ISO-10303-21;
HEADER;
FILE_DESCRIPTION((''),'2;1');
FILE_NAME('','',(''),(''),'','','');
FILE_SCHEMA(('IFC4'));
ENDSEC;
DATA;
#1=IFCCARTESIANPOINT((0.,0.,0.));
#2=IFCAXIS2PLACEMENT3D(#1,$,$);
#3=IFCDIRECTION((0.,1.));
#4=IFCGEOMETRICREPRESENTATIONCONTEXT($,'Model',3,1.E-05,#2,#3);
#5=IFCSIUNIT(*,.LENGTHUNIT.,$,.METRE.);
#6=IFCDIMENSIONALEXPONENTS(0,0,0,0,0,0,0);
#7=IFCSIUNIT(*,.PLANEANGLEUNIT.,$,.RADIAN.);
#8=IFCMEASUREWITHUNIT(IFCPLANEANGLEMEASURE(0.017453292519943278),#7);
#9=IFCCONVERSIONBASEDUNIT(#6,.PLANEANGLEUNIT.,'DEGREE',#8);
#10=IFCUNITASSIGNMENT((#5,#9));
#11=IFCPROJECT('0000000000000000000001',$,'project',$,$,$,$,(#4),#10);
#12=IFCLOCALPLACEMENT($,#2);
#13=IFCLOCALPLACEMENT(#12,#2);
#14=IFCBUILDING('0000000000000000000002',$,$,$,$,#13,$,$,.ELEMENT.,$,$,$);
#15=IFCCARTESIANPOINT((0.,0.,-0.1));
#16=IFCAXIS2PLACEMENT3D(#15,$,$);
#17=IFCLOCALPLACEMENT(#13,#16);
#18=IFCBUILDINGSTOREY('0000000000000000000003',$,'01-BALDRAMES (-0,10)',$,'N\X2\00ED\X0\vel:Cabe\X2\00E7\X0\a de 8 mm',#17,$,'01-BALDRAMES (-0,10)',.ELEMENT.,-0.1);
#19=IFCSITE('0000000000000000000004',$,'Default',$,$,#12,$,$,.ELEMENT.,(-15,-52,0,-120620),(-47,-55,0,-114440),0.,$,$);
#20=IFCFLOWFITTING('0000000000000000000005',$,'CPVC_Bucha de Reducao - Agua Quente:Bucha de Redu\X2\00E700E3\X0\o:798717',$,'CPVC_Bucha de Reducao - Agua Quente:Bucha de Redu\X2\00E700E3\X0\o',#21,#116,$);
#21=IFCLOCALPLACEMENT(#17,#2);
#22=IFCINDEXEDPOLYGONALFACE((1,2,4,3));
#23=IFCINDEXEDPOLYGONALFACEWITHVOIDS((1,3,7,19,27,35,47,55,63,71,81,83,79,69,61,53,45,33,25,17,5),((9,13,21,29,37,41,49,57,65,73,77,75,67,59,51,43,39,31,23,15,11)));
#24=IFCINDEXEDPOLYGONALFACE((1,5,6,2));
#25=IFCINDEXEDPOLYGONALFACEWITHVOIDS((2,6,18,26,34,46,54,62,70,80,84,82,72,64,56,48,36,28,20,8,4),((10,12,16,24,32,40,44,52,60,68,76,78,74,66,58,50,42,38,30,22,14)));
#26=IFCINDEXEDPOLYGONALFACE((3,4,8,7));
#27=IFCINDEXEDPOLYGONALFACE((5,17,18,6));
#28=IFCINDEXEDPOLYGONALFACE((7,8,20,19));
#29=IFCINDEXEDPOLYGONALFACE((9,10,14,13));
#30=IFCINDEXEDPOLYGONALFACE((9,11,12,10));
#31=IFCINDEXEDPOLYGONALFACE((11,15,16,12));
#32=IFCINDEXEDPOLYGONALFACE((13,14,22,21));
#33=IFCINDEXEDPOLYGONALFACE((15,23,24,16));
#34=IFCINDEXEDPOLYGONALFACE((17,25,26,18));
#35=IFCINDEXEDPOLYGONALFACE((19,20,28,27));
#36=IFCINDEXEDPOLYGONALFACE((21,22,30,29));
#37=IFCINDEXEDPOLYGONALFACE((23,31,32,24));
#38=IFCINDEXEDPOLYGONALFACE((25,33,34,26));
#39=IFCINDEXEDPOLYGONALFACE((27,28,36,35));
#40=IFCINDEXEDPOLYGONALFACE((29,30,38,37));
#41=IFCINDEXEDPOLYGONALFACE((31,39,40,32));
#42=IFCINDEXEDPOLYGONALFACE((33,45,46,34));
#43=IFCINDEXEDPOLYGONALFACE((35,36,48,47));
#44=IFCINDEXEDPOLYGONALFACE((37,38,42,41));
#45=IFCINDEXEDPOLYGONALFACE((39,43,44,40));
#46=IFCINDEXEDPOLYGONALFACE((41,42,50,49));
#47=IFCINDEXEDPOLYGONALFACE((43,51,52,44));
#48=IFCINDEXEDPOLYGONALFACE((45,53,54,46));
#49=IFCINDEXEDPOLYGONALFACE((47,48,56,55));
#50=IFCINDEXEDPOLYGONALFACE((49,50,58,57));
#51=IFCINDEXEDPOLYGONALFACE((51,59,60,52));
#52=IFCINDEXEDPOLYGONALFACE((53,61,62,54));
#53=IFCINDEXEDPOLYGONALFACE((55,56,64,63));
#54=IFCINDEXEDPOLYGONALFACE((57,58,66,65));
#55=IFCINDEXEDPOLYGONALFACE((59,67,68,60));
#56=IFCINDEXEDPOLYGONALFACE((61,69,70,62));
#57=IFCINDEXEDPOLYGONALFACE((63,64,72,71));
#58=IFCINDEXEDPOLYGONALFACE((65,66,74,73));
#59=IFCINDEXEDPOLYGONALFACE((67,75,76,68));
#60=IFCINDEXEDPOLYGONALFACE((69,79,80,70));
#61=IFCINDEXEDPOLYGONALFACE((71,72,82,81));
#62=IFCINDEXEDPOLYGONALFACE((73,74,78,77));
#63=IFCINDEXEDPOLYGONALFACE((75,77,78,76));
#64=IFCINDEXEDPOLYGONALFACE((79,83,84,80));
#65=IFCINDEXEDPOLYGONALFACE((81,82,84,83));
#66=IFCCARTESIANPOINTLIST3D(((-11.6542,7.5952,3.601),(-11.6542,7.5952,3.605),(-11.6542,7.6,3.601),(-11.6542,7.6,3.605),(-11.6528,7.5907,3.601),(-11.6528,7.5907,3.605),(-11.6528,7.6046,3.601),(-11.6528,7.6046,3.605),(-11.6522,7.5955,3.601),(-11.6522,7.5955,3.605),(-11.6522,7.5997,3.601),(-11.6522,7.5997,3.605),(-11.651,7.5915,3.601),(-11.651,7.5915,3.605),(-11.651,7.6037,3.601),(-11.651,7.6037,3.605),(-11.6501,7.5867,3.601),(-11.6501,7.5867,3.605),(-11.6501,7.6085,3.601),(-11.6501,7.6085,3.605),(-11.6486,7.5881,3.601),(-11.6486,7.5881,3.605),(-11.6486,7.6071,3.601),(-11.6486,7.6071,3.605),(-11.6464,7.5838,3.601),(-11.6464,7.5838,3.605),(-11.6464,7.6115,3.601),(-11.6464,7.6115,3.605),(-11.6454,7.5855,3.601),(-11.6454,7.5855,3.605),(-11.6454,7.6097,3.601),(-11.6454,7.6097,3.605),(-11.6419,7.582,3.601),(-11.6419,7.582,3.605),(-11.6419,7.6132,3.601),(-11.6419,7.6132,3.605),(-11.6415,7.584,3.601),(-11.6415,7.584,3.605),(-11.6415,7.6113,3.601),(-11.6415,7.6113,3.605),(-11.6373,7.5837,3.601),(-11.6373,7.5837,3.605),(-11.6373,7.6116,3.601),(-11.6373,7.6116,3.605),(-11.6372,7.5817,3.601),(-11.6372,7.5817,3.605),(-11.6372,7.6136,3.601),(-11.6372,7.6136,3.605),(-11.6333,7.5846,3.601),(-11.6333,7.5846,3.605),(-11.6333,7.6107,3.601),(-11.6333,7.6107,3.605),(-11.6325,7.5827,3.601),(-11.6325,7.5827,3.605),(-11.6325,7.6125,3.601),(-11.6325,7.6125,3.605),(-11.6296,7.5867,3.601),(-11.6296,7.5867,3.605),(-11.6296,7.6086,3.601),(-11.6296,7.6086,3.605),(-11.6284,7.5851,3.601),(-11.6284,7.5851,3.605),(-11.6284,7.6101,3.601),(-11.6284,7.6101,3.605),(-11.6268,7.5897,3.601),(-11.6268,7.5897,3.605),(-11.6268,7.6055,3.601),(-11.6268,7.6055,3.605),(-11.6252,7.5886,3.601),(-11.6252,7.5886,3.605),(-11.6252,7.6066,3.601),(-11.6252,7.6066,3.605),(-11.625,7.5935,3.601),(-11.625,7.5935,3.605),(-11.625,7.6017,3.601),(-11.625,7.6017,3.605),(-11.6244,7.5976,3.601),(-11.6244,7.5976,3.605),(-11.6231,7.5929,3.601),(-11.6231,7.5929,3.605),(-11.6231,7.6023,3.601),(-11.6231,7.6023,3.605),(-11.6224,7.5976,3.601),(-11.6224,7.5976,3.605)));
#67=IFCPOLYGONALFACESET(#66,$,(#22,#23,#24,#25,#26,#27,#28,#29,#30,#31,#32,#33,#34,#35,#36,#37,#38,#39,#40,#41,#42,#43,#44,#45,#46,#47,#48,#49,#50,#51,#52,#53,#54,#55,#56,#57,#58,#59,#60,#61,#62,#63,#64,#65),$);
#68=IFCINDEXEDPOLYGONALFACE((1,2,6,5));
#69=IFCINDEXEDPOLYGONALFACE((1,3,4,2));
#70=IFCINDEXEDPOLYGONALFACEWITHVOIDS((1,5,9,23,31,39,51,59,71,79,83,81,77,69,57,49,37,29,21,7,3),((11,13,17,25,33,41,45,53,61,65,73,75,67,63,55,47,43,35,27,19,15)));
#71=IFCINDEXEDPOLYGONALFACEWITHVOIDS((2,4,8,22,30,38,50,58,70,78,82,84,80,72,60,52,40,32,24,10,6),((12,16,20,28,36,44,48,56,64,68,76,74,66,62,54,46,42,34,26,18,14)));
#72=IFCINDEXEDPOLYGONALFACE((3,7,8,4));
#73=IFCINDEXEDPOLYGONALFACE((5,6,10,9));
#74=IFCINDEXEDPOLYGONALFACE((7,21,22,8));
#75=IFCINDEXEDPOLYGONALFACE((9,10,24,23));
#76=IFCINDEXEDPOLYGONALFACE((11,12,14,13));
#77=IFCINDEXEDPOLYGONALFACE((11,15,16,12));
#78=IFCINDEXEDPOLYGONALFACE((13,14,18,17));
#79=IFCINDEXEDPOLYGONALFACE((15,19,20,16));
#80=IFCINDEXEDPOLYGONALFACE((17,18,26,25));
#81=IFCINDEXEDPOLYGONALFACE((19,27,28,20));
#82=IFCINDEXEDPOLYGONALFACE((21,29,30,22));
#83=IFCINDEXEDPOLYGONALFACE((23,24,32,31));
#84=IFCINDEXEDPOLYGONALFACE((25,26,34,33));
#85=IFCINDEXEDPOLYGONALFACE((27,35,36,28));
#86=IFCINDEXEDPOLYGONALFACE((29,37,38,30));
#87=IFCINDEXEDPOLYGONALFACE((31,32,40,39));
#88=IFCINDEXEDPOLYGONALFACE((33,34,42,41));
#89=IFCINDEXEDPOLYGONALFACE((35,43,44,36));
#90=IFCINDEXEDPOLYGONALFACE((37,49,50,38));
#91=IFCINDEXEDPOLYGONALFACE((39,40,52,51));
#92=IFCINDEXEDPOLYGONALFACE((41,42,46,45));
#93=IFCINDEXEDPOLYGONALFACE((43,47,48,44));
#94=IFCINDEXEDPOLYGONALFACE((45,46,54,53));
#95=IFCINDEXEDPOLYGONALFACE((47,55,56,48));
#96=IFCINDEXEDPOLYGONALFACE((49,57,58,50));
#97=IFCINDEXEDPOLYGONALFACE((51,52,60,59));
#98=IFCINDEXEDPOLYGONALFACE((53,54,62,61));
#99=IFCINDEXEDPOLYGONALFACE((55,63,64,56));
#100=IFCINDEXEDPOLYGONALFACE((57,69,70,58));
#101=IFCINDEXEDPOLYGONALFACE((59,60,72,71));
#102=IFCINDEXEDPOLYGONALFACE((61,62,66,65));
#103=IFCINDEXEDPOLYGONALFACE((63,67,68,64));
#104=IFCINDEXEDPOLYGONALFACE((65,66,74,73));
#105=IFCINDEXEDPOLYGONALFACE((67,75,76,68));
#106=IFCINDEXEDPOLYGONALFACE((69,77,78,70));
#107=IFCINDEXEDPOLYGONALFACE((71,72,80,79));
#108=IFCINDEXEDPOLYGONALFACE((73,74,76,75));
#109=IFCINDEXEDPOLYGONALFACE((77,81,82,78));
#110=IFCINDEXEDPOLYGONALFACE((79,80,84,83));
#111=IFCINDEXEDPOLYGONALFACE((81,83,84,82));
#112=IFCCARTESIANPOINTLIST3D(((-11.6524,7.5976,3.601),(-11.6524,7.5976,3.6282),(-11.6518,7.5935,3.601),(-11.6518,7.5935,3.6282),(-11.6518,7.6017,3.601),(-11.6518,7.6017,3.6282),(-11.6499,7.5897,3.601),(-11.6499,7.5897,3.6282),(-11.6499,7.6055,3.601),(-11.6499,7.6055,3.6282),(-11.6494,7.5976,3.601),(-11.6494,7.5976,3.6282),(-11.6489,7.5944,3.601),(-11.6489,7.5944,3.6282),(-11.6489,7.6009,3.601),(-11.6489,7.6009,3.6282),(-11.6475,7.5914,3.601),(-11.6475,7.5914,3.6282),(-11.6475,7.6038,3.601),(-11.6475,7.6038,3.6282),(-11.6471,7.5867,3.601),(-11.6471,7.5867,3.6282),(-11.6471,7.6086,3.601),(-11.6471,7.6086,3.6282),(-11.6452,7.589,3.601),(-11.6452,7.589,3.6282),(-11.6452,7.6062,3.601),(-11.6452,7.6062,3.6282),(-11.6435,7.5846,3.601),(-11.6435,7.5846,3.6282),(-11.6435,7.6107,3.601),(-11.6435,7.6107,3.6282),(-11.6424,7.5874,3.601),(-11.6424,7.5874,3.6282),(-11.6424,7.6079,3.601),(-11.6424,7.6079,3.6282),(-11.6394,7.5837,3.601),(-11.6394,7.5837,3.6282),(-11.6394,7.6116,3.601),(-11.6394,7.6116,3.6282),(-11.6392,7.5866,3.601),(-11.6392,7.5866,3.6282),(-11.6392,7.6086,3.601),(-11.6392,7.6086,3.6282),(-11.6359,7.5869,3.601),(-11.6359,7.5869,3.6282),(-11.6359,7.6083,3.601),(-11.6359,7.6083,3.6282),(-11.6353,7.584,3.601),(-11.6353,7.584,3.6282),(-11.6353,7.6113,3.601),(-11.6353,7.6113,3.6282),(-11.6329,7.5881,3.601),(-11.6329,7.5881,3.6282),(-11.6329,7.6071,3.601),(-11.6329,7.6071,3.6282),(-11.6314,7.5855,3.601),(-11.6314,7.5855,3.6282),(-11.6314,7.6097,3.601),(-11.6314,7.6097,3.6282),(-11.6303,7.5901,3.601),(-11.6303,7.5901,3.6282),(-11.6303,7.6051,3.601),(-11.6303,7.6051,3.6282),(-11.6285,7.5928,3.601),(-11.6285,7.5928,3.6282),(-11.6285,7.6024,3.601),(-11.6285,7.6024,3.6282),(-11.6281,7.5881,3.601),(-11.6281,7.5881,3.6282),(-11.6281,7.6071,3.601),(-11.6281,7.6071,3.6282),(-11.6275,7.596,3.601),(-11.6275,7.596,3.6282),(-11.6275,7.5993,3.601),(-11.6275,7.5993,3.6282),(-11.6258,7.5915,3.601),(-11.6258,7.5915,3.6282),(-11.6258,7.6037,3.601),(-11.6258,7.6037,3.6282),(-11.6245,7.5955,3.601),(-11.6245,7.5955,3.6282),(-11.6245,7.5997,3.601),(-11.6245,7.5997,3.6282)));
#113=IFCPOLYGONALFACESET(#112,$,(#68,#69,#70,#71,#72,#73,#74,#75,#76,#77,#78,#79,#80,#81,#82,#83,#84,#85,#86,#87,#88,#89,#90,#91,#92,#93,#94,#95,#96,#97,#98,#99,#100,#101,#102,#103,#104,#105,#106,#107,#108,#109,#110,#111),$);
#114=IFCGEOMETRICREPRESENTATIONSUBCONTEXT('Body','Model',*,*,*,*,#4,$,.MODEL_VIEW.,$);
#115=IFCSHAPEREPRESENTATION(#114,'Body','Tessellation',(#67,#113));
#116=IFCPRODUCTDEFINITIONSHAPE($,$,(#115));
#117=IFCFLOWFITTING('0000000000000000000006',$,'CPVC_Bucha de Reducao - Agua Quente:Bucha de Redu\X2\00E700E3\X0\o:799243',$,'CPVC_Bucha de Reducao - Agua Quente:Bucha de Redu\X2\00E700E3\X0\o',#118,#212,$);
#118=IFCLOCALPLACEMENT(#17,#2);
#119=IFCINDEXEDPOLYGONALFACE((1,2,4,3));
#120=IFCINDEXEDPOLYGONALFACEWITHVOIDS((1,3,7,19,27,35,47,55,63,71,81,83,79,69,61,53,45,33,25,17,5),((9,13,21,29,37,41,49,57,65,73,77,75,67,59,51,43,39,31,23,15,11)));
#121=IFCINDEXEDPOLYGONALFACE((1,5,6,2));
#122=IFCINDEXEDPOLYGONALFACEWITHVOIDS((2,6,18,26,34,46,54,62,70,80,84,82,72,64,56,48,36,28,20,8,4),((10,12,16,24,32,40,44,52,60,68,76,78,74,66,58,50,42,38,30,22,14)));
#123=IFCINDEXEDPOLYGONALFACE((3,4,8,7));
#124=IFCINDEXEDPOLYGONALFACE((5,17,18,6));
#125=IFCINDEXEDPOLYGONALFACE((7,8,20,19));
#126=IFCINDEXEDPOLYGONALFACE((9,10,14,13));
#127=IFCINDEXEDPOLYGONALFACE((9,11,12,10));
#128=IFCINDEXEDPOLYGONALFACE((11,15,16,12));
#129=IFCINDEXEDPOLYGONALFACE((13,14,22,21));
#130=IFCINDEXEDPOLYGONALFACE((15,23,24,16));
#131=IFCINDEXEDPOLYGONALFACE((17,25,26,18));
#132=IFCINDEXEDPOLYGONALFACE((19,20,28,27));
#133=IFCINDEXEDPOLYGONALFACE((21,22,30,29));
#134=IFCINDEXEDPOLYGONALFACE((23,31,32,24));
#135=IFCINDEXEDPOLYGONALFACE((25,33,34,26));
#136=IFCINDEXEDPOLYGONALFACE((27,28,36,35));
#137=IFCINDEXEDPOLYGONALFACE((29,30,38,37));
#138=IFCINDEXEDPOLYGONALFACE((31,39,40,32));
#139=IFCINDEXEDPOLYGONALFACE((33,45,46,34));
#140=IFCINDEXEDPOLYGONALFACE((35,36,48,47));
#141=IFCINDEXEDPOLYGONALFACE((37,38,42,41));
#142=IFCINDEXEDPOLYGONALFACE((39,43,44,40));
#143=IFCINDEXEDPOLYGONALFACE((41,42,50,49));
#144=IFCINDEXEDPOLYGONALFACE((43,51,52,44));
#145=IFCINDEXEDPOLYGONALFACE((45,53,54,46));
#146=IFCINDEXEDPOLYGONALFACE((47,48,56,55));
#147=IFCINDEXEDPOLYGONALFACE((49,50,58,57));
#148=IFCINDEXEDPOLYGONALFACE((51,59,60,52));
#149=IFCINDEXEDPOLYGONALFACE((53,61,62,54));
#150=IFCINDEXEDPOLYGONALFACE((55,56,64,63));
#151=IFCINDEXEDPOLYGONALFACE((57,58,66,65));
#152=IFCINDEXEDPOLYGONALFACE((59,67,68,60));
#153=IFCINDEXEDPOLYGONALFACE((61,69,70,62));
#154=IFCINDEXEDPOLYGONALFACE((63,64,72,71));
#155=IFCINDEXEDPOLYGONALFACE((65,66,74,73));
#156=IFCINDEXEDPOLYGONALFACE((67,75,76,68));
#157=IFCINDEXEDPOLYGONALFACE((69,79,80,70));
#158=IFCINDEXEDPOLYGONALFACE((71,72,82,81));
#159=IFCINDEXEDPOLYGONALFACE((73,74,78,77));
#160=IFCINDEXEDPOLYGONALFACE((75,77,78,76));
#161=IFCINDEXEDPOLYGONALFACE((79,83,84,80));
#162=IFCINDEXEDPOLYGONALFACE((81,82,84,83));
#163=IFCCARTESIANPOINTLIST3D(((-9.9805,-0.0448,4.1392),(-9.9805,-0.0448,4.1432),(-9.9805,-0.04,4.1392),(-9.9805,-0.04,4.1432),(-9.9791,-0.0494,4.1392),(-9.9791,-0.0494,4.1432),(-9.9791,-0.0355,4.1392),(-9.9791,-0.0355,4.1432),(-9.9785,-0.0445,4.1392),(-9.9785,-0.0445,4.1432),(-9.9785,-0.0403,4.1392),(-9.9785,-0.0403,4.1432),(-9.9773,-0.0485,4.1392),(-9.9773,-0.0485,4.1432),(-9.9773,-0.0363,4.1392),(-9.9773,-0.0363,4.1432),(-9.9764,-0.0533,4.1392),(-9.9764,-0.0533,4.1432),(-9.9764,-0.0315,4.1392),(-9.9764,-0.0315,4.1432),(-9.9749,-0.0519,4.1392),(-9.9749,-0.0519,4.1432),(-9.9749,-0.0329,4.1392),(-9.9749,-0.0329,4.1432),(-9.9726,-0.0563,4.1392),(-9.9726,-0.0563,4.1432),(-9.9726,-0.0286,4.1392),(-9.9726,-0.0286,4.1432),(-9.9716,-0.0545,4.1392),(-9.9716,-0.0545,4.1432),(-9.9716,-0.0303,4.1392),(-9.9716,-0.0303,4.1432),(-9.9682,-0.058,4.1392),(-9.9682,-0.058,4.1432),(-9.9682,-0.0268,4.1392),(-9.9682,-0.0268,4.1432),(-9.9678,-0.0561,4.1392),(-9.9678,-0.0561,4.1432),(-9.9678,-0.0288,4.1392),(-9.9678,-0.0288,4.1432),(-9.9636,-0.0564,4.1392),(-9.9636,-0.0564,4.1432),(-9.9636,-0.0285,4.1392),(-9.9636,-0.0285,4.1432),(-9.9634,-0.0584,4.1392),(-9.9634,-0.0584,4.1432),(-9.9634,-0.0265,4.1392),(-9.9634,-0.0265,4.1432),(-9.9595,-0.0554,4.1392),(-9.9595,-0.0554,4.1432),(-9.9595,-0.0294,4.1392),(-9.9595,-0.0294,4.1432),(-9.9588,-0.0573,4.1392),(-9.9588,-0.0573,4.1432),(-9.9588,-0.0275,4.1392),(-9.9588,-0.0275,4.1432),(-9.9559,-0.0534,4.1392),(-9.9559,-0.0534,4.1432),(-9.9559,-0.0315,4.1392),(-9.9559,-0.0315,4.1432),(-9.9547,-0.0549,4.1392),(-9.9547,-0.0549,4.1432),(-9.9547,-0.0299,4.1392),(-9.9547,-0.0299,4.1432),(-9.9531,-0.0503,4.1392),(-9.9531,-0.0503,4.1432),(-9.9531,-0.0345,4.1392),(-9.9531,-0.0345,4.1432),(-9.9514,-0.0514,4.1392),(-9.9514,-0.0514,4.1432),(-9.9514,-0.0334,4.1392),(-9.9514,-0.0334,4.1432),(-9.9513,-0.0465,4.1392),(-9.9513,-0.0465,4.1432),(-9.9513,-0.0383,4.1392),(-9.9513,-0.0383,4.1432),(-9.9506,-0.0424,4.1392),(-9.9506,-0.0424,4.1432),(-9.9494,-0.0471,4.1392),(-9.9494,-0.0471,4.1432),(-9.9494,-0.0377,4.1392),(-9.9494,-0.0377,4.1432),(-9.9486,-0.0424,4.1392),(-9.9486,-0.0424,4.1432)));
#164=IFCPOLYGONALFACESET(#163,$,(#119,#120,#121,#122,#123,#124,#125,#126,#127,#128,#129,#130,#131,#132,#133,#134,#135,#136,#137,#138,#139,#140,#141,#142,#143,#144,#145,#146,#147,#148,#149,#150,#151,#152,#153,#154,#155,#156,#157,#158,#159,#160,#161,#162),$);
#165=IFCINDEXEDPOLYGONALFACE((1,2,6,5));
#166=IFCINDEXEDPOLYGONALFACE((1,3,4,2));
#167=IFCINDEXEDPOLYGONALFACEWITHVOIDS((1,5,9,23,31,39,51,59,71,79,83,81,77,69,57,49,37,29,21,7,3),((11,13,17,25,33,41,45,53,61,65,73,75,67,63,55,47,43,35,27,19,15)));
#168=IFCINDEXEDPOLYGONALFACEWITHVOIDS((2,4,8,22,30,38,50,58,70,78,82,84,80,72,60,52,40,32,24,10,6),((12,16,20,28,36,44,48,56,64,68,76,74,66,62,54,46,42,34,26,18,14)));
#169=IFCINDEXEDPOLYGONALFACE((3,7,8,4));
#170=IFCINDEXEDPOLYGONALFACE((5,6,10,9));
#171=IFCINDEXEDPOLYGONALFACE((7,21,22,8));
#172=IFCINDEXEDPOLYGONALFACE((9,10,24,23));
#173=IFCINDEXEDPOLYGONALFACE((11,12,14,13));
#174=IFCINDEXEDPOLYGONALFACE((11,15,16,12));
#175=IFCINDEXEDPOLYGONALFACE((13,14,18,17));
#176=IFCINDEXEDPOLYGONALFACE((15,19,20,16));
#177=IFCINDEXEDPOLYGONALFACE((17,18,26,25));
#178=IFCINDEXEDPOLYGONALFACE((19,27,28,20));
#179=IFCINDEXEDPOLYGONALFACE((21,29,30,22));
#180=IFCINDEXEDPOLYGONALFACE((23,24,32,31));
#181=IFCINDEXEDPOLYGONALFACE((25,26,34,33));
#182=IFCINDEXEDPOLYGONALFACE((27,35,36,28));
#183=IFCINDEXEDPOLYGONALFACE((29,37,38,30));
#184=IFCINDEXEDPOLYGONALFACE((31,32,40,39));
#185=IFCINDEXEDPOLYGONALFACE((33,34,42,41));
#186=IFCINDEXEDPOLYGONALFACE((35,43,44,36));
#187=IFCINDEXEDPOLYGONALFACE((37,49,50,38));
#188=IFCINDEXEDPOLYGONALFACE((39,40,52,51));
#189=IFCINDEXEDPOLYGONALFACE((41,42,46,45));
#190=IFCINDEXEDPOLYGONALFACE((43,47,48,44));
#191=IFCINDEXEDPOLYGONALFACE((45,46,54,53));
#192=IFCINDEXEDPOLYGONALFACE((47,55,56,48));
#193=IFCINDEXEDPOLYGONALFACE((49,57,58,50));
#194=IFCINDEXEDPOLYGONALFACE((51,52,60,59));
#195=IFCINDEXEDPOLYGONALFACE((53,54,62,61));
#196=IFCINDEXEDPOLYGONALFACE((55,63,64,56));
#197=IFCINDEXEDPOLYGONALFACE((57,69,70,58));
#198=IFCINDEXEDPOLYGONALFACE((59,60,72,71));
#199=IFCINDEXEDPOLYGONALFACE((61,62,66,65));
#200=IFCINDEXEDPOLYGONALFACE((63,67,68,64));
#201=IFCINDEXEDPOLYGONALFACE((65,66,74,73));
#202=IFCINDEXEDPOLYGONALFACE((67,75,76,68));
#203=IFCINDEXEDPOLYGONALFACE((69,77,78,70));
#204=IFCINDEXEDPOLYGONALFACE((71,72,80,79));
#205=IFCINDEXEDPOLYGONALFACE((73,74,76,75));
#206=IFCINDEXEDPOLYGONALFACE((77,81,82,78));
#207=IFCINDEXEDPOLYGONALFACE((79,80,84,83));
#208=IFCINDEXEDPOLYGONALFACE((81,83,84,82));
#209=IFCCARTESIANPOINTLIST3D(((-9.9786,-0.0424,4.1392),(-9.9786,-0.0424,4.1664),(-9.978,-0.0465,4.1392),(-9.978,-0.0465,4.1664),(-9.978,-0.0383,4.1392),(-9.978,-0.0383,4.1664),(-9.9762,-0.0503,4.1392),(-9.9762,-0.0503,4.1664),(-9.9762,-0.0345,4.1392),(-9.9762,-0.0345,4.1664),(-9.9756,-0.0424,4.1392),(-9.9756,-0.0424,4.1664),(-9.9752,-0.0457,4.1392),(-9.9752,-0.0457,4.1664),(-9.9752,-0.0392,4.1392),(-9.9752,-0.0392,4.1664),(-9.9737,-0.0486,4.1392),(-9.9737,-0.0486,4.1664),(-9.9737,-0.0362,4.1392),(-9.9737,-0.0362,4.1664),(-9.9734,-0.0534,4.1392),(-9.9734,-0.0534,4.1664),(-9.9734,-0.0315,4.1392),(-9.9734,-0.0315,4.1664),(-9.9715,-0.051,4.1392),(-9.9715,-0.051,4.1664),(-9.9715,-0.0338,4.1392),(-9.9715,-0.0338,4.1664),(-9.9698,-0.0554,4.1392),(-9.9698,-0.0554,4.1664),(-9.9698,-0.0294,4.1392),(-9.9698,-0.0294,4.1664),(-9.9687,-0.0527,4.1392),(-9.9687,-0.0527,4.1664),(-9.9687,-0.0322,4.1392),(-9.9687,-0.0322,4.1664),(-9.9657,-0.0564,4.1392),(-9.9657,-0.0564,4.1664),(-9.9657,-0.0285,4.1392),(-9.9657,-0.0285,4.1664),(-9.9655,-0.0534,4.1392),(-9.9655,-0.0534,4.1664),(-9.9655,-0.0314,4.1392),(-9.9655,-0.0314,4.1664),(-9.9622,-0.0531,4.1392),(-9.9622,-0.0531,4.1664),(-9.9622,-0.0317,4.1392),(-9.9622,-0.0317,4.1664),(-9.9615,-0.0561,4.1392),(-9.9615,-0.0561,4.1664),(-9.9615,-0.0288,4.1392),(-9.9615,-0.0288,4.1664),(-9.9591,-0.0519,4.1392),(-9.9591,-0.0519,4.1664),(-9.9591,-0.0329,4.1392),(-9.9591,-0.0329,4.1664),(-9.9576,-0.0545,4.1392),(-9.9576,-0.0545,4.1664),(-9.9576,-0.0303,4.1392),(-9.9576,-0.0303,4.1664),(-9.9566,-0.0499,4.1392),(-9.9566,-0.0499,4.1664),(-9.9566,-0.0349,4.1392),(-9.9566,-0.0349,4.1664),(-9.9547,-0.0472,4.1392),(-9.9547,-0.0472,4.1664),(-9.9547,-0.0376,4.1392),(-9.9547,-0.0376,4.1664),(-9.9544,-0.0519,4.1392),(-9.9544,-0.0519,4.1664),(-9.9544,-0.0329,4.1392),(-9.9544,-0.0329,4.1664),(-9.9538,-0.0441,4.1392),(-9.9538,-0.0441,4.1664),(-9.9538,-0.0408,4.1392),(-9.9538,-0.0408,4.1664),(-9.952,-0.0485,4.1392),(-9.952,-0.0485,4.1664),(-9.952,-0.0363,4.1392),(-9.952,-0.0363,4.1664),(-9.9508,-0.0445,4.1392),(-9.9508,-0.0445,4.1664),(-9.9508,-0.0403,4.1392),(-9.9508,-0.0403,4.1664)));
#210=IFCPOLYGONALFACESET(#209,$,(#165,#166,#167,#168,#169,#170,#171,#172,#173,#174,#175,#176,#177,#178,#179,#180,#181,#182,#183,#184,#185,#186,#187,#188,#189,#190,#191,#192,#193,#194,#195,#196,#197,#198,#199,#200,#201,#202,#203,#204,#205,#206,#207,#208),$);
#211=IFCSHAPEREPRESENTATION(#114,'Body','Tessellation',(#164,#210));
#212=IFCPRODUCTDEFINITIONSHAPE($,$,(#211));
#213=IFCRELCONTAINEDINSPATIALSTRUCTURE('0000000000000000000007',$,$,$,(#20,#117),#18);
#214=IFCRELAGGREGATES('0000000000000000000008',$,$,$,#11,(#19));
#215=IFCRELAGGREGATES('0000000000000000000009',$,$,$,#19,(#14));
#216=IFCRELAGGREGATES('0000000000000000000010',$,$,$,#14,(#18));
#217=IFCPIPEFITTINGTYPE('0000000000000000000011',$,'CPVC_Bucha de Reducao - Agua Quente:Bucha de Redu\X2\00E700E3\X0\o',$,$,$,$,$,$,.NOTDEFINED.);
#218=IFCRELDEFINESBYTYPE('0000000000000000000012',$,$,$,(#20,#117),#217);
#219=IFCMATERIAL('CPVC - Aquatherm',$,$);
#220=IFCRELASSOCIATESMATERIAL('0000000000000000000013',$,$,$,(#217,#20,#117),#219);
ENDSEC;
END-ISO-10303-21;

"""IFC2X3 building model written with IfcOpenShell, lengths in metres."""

from ifc_helpers import new_model, entity, si_unit, converted_unit, direction, frame, frame_2d, origin, place, context, subcontext, project, spatial, hollow_circle, extrude, source, transform, mapped, material, type_object, type_shapes, element, save


model = new_model("IFC2X3")

# Units and contexts
model_context = context("Model", 3, precision=1e-05, world=origin(), true_north=direction((0.0, 1.0)))
body_context = subcontext(model_context, "Body", "Model", "MODEL_VIEW")
ifc_project = project(units=[si_unit("LENGTHUNIT", "METRE"), converted_unit("PLANEANGLEUNIT", "DEGREE", entity("IfcPlaneAngleMeasure", 0.017453292519943278), si_unit("PLANEANGLEUNIT", "RADIAN"), dimensions=[0, 0, 0, 0, 0, 0, 0])], contexts=[model_context])

# Site, building, storey
site_placement = place(None, origin())
site = spatial("IfcSite", under=ifc_project, at=site_placement, Name="Default", CompositionType="ELEMENT", RefLatitude=(-15, -52, 0, -120620), RefLongitude=(-47, -55, 0, -114440), RefElevation=0.0)
building_placement = place(site_placement, origin())
building = spatial("IfcBuilding", under=site, at=building_placement, CompositionType="ELEMENT")
storey_placement = place(building_placement, frame((0.0, 0.0, -0.1)))
storey = spatial("IfcBuildingStorey", under=building, at=storey_placement, Name="01-BALDRAMES (-0,10)", ObjectType="Nível:Cabeça de 8 mm", LongName="01-BALDRAMES (-0,10)", CompositionType="ELEMENT", Elevation=-0.1)

# Flow fittings
ifc_material_1 = material(Name="CPVC - Aquatherm")
pipe_fitting_type_1 = type_object("IfcPipeFittingType", Name="CPVC_Bucha de Reducao - Agua Quente:Bucha de Redução", PredefinedType="NOTDEFINED", material=ifc_material_1)
shared_shape_1 = source(origin(), body_context, "Body", "SweptSolid", [
    extrude(hollow_circle(Radius=0.016, WallThickness=0.002, at=frame_2d((0.0, 0.0), x_axis=(1.0, 0.0))), frame((0.0232, 0.0, 0.0), z_axis=(1.0, 0.0, 0.0), x_axis=(0.0, 1.0, 0.0)), (0.0, 0.0, 1.0), 0.004),
    extrude(hollow_circle(Radius=0.014, WallThickness=0.003, at=frame_2d((0.0, 0.0), x_axis=(1.0, 0.0))), frame((0.0, 0.0, 0.0), z_axis=(1.0, 0.0, 0.0), x_axis=(0.0, -1.0, 0.0)), (0.0, 0.0, 1.0), 0.0272),
])
type_shapes(pipe_fitting_type_1, [shared_shape_1])
for number, where, z_axis, x_axis, name in (
    (1, (-11.6384, 7.5976, 3.6282), (0.0, -1.0, 0.0), (0.0, 0.0, -1.0), "CPVC_Bucha de Reducao - Agua Quente:Bucha de Redução:798717"),
    (2, (-9.9646, -0.0424, 4.1664), (0.0, -1.0, 0.0), (0.0, 0.0, -1.0), "CPVC_Bucha de Reducao - Agua Quente:Bucha de Redução:799243"),
):
    element("IfcFlowFitting", number, at=place(storey_placement, frame(where, z_axis=z_axis, x_axis=x_axis)), inside=storey, type_object=pipe_fitting_type_1, material=ifc_material_1, Name=name, ObjectType="CPVC_Bucha de Reducao - Agua Quente:Bucha de Redução", context=body_context, shape_type="MappedRepresentation", body=[
        mapped(shared_shape_1, transform((0.0, 0.0, 0.0), scale=1.0)),
    ])

save(model, "model.ifc")
